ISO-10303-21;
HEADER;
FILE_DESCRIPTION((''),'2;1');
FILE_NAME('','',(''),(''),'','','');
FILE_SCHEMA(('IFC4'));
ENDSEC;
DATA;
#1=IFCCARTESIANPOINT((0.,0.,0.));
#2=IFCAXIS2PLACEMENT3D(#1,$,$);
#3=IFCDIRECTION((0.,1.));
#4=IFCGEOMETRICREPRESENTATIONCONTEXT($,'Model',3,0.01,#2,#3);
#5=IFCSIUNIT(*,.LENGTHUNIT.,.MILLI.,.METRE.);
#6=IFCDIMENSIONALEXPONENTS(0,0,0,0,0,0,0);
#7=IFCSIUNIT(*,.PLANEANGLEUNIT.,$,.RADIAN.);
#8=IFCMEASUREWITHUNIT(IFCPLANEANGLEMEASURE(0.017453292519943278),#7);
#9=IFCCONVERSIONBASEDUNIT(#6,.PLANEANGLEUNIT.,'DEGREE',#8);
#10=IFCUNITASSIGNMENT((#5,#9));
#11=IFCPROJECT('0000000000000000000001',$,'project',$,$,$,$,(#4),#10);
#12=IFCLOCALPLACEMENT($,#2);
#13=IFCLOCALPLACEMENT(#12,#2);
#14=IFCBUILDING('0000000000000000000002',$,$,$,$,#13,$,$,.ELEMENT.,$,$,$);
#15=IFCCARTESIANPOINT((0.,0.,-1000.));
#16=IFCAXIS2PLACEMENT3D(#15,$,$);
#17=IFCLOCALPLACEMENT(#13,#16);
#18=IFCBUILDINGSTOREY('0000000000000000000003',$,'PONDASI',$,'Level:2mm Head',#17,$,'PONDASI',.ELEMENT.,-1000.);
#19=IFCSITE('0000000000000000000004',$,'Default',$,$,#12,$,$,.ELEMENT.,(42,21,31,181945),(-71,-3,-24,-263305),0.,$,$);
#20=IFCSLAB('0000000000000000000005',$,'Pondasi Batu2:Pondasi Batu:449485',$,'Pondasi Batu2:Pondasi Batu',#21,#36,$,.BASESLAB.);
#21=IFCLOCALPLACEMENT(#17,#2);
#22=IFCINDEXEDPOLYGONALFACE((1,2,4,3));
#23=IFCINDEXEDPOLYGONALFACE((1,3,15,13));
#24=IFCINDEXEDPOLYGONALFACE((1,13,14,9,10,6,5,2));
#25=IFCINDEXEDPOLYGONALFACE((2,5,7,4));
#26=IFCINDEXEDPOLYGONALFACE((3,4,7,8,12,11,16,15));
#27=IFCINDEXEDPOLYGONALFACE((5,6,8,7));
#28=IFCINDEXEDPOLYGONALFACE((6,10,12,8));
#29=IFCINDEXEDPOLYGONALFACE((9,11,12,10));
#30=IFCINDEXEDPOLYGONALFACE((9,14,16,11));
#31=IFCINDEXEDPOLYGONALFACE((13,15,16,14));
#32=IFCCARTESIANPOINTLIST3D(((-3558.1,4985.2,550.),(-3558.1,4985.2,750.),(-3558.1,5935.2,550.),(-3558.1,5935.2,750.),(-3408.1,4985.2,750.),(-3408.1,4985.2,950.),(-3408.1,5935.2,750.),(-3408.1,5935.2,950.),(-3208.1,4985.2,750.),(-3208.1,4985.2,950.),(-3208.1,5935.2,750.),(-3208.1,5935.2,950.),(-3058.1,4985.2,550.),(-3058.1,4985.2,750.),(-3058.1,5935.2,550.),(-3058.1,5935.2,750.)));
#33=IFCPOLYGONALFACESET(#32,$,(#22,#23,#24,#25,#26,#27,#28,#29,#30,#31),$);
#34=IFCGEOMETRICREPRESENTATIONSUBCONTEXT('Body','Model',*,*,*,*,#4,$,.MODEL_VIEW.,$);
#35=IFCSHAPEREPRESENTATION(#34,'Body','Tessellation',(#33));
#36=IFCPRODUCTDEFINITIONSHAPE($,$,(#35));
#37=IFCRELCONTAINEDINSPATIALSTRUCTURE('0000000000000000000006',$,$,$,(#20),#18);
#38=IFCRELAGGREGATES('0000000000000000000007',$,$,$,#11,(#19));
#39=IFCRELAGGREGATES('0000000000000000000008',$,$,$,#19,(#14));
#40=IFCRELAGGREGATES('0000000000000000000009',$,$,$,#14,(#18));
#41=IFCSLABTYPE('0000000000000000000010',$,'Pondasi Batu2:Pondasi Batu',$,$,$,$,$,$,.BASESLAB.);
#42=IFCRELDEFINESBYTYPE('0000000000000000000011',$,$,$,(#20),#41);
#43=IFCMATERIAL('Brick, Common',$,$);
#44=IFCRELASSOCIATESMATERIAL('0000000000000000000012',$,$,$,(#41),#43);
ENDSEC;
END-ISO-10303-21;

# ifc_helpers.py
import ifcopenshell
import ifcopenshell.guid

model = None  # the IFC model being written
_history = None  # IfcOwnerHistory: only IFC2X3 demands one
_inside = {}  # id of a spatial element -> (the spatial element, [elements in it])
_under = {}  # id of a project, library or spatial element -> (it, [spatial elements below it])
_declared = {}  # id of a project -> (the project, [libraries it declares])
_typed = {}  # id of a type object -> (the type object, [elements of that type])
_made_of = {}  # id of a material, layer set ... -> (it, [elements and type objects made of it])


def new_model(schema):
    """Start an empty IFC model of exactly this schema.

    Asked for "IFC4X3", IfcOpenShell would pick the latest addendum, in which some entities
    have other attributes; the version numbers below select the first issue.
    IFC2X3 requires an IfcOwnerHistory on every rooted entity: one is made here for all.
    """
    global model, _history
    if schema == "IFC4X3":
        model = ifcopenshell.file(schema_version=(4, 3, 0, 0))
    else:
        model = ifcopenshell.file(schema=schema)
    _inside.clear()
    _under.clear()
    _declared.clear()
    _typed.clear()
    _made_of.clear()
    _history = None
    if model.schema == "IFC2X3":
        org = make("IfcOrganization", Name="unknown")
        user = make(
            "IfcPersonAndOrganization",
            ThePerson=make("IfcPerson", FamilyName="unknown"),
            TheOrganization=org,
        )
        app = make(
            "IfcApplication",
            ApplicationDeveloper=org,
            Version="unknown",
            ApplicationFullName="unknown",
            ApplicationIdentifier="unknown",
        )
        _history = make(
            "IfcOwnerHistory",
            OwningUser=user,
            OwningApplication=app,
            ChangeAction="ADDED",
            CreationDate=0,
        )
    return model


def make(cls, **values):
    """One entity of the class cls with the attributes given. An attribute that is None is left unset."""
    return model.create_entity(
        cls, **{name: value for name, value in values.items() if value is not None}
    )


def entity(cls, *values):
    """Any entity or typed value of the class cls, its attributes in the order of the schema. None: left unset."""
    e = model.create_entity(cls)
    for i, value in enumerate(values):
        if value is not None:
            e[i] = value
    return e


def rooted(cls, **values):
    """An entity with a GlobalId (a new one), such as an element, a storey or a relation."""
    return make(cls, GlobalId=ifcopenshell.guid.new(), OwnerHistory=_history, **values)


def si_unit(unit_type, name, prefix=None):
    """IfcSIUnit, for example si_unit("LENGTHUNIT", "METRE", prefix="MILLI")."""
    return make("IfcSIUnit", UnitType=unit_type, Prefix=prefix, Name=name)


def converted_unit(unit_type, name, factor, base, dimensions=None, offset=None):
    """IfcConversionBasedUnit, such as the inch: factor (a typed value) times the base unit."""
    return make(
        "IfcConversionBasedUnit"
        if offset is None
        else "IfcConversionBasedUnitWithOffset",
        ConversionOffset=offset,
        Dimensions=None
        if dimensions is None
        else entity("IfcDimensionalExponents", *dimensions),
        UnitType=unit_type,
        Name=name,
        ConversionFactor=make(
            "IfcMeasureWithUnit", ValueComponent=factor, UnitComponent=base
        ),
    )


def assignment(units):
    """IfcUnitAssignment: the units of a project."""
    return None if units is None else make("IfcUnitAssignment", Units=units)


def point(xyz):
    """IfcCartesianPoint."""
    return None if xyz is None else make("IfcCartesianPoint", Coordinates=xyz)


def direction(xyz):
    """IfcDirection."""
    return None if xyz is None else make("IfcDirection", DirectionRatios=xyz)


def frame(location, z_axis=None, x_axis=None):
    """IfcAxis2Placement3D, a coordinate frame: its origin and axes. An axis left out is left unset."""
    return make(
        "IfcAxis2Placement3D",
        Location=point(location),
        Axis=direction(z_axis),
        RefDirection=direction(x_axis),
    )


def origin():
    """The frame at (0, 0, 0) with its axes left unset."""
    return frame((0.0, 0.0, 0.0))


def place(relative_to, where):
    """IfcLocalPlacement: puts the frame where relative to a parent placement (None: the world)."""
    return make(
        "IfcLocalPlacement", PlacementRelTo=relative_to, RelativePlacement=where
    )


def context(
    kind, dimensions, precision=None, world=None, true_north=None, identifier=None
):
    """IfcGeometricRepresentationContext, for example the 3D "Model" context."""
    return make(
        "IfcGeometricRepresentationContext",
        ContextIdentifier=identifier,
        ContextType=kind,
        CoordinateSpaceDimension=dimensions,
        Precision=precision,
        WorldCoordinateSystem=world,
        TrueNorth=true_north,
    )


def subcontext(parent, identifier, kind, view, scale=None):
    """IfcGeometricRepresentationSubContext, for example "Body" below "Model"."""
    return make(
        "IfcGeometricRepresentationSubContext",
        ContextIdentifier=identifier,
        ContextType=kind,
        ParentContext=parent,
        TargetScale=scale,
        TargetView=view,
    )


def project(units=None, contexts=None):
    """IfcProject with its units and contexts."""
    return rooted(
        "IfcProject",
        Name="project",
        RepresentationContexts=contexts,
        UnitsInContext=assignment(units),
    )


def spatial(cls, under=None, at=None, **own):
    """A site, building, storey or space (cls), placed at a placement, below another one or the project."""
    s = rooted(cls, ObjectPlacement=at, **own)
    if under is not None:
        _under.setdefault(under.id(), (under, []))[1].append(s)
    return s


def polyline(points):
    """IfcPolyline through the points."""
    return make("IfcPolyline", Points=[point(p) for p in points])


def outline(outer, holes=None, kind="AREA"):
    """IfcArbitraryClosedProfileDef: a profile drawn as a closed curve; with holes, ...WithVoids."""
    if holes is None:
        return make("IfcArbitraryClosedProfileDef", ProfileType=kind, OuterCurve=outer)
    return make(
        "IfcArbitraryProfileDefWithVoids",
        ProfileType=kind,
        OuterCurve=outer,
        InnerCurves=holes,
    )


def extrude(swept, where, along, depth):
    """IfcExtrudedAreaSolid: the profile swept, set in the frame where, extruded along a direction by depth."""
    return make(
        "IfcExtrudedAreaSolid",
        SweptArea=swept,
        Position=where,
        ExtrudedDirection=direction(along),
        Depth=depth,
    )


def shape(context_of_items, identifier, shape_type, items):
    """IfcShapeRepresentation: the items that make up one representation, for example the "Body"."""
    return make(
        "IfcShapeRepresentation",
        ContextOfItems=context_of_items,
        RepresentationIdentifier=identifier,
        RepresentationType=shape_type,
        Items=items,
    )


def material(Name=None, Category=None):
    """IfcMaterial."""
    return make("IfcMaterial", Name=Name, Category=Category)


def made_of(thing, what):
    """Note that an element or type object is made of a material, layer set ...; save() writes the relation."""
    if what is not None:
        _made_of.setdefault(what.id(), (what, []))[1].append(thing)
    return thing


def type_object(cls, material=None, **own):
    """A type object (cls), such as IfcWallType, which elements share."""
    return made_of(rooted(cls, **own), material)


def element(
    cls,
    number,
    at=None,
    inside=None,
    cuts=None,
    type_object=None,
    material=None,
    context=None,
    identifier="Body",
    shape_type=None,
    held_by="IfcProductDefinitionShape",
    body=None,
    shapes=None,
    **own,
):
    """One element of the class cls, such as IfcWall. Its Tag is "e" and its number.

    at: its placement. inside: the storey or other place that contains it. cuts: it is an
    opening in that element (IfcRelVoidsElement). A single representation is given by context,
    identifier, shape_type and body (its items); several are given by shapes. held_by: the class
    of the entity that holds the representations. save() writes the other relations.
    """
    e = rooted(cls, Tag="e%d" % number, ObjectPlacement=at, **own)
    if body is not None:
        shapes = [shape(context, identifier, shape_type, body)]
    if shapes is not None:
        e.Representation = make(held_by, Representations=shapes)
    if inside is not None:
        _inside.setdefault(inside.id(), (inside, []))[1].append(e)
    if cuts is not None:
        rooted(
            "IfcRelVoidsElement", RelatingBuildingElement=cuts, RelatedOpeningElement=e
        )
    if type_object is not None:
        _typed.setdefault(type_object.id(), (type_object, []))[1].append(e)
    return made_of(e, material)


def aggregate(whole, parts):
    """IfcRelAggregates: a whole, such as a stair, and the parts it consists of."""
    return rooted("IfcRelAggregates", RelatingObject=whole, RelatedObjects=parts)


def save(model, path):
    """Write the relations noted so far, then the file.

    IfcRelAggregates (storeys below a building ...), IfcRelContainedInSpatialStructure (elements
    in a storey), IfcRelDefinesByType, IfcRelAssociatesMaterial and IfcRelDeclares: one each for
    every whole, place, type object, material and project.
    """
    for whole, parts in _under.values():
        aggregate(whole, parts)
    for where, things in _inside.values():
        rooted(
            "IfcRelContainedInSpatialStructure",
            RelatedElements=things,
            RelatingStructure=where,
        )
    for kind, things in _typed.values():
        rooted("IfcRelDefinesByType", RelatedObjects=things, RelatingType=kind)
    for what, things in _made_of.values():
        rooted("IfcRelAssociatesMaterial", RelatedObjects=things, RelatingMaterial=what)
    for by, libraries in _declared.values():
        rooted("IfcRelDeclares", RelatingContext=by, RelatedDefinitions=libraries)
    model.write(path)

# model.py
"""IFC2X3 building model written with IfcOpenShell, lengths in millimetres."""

from ifc_helpers import new_model, entity, si_unit, converted_unit, direction, frame, origin, place, context, subcontext, project, spatial, polyline, outline, extrude, material, type_object, element, save


model = new_model("IFC2X3")

# Units and contexts
model_context = context("Model", 3, precision=0.01, world=origin(), true_north=direction((0.0, 1.0)))
body_context = subcontext(model_context, "Body", "Model", "MODEL_VIEW")
ifc_project = project(units=[si_unit("LENGTHUNIT", "METRE", prefix="MILLI"), converted_unit("PLANEANGLEUNIT", "DEGREE", entity("IfcPlaneAngleMeasure", 0.017453292519943278), si_unit("PLANEANGLEUNIT", "RADIAN"), dimensions=[0, 0, 0, 0, 0, 0, 0])], contexts=[model_context])

# Site, building, storey
site_placement = place(None, origin())
site = spatial("IfcSite", under=ifc_project, at=site_placement, Name="Default", CompositionType="ELEMENT", RefLatitude=(42, 21, 31, 181945), RefLongitude=(-71, -3, -24, -263305), RefElevation=0.0)
building_placement = place(site_placement, origin())
building = spatial("IfcBuilding", under=site, at=building_placement, CompositionType="ELEMENT")
storey_placement = place(building_placement, frame((0.0, 0.0, -1000.0)))
storey = spatial("IfcBuildingStorey", under=building, at=storey_placement, Name="PONDASI", ObjectType="Level:2mm Head", LongName="PONDASI", CompositionType="ELEMENT", Elevation=-1000.0)

# Slab
ifc_material_1 = material(Name="Brick, Common")
slab_type_1 = type_object("IfcSlabType", Name="Pondasi Batu2:Pondasi Batu", PredefinedType="BASESLAB", material=ifc_material_1)
slab_1_placement = place(storey_placement, origin())
element("IfcSlab", 1, at=slab_1_placement, inside=storey, type_object=slab_type_1, Name="Pondasi Batu2:Pondasi Batu:449485", ObjectType="Pondasi Batu2:Pondasi Batu", PredefinedType="BASESLAB", context=body_context, shape_type="SweptSolid", body=[
    extrude(outline(polyline([(-100.0, -200.0), (100.0, -200.0), (100.0, 0.0), (250.0, 0.0), (250.0, 200.0), (-250.0, 200.0), (-250.0, 0.0), (-100.0, 0.0), (-100.0, -200.0)])), frame((-3308.1, 4985.2, 750.0), z_axis=(0.0, 1.0, 0.0), x_axis=(1.0, 0.0, 0.0)), (0.0, 0.0, 1.0), 950.0),
])

save(model, "model.ifc")
